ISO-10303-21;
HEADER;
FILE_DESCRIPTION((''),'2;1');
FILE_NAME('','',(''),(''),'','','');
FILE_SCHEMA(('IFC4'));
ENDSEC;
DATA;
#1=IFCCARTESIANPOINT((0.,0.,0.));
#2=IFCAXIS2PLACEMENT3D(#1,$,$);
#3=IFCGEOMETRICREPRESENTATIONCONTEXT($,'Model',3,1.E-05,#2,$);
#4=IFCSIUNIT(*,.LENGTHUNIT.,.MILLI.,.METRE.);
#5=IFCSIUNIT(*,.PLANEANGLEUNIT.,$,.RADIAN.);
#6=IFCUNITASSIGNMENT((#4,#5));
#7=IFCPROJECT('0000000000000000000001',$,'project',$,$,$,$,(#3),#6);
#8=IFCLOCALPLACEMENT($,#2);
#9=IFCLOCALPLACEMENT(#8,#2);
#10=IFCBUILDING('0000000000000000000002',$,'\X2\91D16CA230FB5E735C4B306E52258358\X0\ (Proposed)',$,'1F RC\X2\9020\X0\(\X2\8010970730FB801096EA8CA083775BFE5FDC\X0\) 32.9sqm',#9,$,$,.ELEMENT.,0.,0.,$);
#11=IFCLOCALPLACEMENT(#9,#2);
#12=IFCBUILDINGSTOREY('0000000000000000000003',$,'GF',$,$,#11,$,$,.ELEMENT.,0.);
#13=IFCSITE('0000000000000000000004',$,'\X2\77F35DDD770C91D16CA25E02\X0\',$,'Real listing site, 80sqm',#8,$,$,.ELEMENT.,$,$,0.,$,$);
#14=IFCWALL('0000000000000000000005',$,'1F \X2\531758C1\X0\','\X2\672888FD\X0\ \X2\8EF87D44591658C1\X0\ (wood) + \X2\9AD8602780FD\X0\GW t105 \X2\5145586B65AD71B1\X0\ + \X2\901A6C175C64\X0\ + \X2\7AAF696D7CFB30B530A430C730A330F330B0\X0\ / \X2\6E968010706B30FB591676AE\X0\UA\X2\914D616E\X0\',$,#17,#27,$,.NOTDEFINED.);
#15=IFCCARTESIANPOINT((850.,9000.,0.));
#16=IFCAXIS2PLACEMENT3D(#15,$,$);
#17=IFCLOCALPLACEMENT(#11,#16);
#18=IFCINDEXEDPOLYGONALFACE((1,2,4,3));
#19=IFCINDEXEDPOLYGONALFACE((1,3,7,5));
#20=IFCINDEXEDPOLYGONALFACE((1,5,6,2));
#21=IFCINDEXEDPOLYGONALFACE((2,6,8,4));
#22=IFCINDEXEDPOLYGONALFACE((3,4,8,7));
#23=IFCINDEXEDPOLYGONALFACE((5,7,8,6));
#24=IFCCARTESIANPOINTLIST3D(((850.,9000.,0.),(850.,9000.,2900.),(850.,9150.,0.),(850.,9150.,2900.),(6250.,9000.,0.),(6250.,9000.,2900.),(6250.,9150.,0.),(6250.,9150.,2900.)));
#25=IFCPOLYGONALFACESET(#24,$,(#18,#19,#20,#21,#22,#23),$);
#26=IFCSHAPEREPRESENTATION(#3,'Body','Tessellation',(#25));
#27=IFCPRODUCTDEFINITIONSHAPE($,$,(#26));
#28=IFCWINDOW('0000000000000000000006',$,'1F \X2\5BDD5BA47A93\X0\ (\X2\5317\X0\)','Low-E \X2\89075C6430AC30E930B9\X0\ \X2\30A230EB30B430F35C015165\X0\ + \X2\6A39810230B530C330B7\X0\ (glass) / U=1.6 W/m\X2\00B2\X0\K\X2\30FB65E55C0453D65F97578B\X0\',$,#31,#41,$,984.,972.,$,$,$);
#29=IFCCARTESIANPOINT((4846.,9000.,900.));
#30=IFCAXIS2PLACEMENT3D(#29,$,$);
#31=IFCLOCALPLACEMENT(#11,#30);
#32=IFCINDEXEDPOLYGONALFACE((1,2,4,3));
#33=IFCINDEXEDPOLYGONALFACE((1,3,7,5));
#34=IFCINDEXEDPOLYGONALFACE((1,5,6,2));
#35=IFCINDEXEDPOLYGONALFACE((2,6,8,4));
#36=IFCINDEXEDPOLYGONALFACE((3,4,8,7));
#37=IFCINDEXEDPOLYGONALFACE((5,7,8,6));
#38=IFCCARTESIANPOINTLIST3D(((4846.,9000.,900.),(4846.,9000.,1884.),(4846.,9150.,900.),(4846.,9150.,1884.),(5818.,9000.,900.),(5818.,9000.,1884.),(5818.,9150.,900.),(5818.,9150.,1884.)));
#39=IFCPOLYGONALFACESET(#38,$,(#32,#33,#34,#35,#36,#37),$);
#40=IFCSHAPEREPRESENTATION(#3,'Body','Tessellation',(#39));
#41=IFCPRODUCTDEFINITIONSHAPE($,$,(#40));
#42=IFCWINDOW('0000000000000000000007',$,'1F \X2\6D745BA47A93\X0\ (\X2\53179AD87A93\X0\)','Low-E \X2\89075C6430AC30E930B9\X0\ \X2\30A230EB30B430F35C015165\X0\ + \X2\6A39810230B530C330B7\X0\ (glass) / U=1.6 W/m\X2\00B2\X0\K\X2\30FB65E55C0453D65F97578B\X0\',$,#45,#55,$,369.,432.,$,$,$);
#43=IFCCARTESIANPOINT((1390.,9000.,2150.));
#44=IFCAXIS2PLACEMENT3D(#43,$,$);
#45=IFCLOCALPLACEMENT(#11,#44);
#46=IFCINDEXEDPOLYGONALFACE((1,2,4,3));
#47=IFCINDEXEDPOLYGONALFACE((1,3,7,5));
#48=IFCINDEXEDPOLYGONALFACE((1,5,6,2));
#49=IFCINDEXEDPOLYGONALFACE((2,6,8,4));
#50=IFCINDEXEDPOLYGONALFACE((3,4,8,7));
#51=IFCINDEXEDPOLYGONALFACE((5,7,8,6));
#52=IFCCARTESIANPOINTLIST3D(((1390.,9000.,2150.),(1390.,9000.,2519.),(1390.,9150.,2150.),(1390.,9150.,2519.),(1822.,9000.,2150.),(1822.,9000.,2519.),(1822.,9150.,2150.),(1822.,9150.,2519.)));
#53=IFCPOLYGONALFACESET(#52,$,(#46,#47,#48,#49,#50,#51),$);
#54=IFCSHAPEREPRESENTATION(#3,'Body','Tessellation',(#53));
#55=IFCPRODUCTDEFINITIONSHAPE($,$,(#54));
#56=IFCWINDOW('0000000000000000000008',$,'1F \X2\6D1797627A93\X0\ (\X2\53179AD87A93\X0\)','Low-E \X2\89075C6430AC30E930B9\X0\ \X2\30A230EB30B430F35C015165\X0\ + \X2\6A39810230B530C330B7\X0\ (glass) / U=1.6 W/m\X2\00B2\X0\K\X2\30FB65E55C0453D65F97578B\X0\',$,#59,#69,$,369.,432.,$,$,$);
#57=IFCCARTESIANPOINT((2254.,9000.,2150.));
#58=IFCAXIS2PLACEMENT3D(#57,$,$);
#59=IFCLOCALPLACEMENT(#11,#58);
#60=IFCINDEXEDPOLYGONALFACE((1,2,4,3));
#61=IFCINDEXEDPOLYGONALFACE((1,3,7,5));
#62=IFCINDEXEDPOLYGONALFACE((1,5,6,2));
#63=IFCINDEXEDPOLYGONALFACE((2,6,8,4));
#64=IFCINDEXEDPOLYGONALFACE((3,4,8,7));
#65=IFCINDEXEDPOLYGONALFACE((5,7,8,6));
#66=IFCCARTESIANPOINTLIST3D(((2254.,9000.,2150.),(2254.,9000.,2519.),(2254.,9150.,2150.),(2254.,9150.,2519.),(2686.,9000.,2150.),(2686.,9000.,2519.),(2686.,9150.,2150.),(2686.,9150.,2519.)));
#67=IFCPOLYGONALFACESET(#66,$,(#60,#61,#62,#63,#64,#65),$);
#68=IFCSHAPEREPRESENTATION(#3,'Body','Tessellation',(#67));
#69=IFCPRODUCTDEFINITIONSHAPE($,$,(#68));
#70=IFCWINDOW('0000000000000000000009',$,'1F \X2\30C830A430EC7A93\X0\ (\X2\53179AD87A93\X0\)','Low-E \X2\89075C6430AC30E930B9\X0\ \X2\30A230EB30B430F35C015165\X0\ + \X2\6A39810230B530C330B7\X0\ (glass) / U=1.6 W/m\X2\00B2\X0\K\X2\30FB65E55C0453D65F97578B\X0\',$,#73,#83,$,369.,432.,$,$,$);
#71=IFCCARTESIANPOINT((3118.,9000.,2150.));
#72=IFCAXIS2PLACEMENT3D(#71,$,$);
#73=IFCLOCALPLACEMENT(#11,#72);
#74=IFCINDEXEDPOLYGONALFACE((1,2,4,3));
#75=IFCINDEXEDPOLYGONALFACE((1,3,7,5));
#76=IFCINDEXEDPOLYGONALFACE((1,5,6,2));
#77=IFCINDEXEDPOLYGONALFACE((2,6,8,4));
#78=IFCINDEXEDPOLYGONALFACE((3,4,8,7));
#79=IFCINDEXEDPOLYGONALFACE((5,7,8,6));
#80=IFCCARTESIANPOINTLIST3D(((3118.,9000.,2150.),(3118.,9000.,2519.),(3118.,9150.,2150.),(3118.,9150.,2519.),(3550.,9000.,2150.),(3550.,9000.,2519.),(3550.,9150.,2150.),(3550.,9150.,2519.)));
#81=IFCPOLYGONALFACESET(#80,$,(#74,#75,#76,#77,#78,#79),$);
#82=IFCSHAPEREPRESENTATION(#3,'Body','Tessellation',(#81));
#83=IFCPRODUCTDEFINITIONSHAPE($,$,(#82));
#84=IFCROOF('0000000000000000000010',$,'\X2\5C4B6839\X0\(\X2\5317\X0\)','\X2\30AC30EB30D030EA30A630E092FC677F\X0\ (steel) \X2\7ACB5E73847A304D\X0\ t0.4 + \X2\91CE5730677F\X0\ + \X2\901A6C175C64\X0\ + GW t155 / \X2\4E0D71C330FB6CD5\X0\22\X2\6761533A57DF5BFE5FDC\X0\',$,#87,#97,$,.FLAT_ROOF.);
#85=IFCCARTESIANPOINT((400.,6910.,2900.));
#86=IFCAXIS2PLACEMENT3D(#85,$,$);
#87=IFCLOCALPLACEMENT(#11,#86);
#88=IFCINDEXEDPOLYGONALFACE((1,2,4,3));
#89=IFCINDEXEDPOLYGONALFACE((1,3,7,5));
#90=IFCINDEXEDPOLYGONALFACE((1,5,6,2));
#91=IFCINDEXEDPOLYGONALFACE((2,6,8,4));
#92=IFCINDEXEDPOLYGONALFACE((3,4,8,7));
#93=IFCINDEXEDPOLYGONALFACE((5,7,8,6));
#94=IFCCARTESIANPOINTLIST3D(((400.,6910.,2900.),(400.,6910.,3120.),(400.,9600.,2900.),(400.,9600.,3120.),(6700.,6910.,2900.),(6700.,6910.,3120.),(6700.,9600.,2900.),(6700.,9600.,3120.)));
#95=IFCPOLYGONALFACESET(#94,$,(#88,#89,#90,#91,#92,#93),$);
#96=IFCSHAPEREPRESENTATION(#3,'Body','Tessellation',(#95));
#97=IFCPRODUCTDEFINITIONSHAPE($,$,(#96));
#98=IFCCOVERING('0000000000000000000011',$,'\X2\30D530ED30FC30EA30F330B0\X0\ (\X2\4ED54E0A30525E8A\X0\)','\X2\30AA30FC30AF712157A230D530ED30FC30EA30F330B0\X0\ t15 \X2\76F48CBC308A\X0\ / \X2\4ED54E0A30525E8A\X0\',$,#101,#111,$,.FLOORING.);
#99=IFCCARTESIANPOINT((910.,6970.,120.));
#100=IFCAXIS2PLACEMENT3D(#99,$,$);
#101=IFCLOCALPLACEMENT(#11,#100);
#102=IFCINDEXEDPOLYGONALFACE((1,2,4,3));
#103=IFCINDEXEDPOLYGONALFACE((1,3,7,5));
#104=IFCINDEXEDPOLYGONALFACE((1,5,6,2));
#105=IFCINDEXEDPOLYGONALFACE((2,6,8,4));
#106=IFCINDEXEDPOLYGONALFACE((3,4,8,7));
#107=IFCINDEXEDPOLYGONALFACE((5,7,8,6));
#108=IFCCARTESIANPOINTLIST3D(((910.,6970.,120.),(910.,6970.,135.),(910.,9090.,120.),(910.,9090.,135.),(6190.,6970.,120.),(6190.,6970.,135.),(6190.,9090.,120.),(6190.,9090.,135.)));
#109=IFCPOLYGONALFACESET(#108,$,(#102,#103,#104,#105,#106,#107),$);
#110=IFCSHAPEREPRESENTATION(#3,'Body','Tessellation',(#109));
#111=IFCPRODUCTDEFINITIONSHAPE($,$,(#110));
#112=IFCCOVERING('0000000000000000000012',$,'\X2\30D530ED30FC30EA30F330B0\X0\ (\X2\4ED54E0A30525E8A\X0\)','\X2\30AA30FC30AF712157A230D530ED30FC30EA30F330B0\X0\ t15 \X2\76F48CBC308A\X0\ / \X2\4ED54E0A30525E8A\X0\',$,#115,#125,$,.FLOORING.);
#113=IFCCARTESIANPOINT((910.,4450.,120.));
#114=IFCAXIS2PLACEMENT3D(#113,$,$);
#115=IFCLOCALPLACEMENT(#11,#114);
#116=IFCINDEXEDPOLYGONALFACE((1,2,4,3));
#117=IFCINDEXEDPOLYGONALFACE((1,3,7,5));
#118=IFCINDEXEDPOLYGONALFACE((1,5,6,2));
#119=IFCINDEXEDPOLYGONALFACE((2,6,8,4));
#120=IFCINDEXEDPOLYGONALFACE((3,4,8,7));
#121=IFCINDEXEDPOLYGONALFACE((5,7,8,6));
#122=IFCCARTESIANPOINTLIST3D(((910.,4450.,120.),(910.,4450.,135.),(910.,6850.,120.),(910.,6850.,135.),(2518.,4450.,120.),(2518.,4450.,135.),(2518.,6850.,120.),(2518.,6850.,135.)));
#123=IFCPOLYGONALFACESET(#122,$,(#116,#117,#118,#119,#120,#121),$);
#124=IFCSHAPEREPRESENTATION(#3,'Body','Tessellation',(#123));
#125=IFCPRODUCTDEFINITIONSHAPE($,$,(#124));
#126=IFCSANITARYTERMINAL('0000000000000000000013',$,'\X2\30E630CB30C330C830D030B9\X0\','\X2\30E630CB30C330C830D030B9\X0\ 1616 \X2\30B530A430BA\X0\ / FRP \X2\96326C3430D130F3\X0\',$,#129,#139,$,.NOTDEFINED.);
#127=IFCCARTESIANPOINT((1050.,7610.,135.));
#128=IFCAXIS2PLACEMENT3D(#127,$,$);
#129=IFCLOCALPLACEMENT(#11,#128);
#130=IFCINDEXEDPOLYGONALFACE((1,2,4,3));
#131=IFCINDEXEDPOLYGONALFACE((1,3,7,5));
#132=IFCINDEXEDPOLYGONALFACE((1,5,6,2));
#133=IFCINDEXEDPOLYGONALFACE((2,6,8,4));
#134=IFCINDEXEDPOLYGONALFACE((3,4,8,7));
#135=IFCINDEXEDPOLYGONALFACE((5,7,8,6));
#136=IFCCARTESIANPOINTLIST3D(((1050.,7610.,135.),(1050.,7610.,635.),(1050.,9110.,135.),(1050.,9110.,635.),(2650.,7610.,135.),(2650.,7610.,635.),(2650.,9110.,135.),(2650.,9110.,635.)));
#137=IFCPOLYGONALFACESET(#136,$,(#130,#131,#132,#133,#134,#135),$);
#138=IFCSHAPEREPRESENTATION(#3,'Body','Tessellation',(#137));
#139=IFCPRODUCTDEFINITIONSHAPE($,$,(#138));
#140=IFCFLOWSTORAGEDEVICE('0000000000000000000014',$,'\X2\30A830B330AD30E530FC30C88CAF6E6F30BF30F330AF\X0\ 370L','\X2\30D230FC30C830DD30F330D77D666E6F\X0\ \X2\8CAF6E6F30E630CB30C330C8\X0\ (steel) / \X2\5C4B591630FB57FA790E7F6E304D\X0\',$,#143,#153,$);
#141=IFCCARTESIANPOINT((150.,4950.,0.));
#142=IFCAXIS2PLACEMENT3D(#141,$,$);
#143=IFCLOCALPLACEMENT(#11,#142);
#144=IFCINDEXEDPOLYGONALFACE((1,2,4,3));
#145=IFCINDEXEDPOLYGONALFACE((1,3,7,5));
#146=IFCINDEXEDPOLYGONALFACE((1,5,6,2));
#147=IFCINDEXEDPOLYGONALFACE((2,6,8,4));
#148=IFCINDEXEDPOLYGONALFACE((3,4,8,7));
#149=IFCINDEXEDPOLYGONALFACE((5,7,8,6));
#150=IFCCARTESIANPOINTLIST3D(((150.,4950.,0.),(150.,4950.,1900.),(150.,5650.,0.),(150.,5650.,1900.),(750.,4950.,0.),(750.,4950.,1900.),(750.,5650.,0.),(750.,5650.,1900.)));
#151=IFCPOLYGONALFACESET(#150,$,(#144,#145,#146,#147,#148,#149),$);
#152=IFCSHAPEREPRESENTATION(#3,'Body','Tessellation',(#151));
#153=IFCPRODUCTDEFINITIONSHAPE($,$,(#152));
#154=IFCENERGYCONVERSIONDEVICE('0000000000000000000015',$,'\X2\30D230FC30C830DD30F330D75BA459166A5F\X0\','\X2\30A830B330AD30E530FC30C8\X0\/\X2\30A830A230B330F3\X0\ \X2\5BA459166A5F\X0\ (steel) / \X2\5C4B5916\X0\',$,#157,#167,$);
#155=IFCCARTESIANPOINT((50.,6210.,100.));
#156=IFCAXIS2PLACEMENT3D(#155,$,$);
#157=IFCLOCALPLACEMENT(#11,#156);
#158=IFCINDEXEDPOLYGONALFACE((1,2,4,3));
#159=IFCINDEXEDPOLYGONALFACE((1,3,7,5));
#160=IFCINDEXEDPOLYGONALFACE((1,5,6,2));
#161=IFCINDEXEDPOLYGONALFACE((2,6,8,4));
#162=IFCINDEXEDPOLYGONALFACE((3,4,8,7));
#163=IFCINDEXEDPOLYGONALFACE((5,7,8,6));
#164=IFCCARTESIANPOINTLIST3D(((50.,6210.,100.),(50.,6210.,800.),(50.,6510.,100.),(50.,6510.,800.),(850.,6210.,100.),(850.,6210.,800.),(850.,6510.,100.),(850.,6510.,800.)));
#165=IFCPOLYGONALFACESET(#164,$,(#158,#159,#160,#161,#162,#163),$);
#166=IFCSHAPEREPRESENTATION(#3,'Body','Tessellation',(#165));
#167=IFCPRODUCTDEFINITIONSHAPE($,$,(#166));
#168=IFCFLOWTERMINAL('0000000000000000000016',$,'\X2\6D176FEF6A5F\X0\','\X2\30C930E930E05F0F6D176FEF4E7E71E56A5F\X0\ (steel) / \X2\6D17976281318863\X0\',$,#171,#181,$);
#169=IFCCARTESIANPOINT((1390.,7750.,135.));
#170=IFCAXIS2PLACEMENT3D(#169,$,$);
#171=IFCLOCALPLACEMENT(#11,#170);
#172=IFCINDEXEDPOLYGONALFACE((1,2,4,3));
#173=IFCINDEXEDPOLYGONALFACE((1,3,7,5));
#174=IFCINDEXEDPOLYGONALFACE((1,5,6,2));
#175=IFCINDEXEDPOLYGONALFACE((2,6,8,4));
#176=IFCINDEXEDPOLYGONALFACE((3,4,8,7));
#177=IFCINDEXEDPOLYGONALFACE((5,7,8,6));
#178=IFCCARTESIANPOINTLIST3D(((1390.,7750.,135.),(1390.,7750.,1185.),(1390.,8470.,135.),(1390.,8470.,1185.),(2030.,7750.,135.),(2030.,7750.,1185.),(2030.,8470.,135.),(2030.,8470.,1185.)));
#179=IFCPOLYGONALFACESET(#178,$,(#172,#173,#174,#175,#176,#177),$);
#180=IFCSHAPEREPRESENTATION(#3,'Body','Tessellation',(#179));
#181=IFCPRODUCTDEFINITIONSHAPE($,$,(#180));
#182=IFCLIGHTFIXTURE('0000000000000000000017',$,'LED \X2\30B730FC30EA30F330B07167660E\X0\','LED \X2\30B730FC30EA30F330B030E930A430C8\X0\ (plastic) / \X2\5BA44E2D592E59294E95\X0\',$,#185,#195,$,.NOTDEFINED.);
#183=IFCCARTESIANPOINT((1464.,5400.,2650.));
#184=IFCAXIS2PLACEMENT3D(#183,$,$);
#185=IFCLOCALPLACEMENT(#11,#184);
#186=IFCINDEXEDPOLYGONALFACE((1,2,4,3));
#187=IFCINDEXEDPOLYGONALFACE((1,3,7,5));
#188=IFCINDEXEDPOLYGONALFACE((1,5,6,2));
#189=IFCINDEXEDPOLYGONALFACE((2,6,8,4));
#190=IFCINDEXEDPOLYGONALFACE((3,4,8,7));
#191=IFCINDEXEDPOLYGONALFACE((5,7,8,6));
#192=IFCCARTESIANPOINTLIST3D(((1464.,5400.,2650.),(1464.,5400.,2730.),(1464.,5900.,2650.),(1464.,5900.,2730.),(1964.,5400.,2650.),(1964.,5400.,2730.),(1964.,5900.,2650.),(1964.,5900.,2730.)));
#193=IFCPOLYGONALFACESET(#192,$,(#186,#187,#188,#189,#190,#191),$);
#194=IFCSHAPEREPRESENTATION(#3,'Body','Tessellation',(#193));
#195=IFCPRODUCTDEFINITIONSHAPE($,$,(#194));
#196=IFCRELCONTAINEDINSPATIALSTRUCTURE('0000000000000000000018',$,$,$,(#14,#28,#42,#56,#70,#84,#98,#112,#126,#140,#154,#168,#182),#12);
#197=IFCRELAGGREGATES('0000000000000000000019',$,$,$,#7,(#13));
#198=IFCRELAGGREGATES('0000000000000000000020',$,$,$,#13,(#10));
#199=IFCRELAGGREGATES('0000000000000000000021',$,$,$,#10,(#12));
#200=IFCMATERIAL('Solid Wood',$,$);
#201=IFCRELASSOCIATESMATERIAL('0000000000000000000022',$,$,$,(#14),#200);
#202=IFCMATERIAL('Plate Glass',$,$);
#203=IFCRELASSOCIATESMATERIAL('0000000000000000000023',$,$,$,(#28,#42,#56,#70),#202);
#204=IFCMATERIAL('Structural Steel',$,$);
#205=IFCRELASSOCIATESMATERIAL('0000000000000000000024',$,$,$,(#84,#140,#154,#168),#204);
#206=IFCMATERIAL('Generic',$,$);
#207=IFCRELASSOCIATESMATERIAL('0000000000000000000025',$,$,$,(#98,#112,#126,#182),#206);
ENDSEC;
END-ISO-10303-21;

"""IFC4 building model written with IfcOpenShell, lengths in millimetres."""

from ifc_helpers import new_model, si_unit, frame, frame_2d, origin, place, context, project, spatial, rectangle, extrude, material, element, fill, save


model = new_model("IFC4")

# Units and contexts
model_context = context("Model", 3, precision=1e-05, world=origin())
ifc_project = project(units=[si_unit("LENGTHUNIT", "METRE", prefix="MILLI"), si_unit("PLANEANGLEUNIT", "RADIAN")], contexts=[model_context])

# Site, building, storey
site_placement = place(None, origin())
site = spatial("IfcSite", under=ifc_project, at=site_placement, Name="石川県金沢市", ObjectType="Real listing site, 80sqm", CompositionType="ELEMENT", RefElevation=0.0)
building_placement = place(site_placement, origin())
building = spatial("IfcBuilding", under=site, at=building_placement, Name="金沢・平屋の別荘 (Proposed)", ObjectType="1F RC造(耐震・耐雪負荷対応) 32.9sqm", CompositionType="ELEMENT", ElevationOfRefHeight=0.0, ElevationOfTerrain=0.0)
storey_placement = place(building_placement, origin())
storey = spatial("IfcBuildingStorey", under=building, at=storey_placement, Name="GF", CompositionType="ELEMENT", Elevation=0.0)

# Shared definitions
ifc_material_1 = material(Name="Solid Wood")

# Wall, openings, windows
wall_1_placement = place(storey_placement, frame((850.0, 9000.0, 0.0)))
wall_1 = element("IfcWall", 1, at=wall_1_placement, inside=storey, material=ifc_material_1, Name="1F 北壁", Description="木製 軸組外壁 (wood) + 高性能GW t105 充填断熱 + 通気層 + 窯業系サイディング / 準耐火・外皮UA配慮", PredefinedType="NOTDEFINED", context=model_context, shape_type="SweptSolid", body=[
    extrude(rectangle(XDim=5400.0, YDim=150.0, at=frame_2d((2700.0, 75.0))), frame((850.0, 9000.0, 0.0)), (0.0, 0.0, 1.0), 2900.0),
])
opening_1_placement = place(storey_placement, frame((4846.0, 9000.0, 900.0)))
opening_1 = element("IfcOpeningElement", 2, at=opening_1_placement, cuts=wall_1, PredefinedType="NOTDEFINED", context=model_context, shape_type="SweptSolid", body=[
    extrude(rectangle(XDim=972.0, YDim=150.0, at=frame_2d((486.0, 75.0))), frame((4846.0, 9000.0, 900.0)), (0.0, 0.0, 1.0), 984.0),
])
opening_2_placement = place(storey_placement, frame((1390.0, 9000.0, 2150.0)))
opening_2 = element("IfcOpeningElement", 3, at=opening_2_placement, cuts=wall_1, PredefinedType="NOTDEFINED", context=model_context, shape_type="SweptSolid", body=[
    extrude(rectangle(XDim=432.0, YDim=150.0, at=frame_2d((216.0, 75.0))), frame((1390.0, 9000.0, 2150.0)), (0.0, 0.0, 1.0), 369.0),
])
opening_3_placement = place(storey_placement, frame((2254.0, 9000.0, 2150.0)))
opening_3 = element("IfcOpeningElement", 4, at=opening_3_placement, cuts=wall_1, PredefinedType="NOTDEFINED", context=model_context, shape_type="SweptSolid", body=[
    extrude(rectangle(XDim=432.0, YDim=150.0, at=frame_2d((216.0, 75.0))), frame((2254.0, 9000.0, 2150.0)), (0.0, 0.0, 1.0), 369.0),
])
opening_4_placement = place(storey_placement, frame((3118.0, 9000.0, 2150.0)))
opening_4 = element("IfcOpeningElement", 5, at=opening_4_placement, cuts=wall_1, PredefinedType="NOTDEFINED", context=model_context, shape_type="SweptSolid", body=[
    extrude(rectangle(XDim=432.0, YDim=150.0, at=frame_2d((216.0, 75.0))), frame((3118.0, 9000.0, 2150.0)), (0.0, 0.0, 1.0), 369.0),
])
ifc_material_2 = material(Name="Plate Glass")
window_1_placement = place(storey_placement, frame((4846.0, 9000.0, 900.0)))
window_1 = element("IfcWindow", 6, at=window_1_placement, inside=storey, material=ifc_material_2, Name="1F 寝室窓 (北)", Description="Low-E 複層ガラス アルゴン封入 + 樹脂サッシ (glass) / U=1.6 W/m²K・日射取得型", OverallHeight=984.0, OverallWidth=972.0, context=model_context, shape_type="SweptSolid", body=[
    extrude(rectangle(XDim=972.0, YDim=150.0, at=frame_2d((486.0, 75.0))), frame((4846.0, 9000.0, 900.0)), (0.0, 0.0, 1.0), 984.0),
])
fill(opening_1, window_1)
window_2_placement = place(storey_placement, frame((1390.0, 9000.0, 2150.0)))
window_2 = element("IfcWindow", 7, at=window_2_placement, inside=storey, material=ifc_material_2, Name="1F 浴室窓 (北高窓)", Description="Low-E 複層ガラス アルゴン封入 + 樹脂サッシ (glass) / U=1.6 W/m²K・日射取得型", OverallHeight=369.0, OverallWidth=432.0, context=model_context, shape_type="SweptSolid", body=[
    extrude(rectangle(XDim=432.0, YDim=150.0, at=frame_2d((216.0, 75.0))), frame((1390.0, 9000.0, 2150.0)), (0.0, 0.0, 1.0), 369.0),
])
fill(opening_2, window_2)
window_3_placement = place(storey_placement, frame((2254.0, 9000.0, 2150.0)))
window_3 = element("IfcWindow", 8, at=window_3_placement, inside=storey, material=ifc_material_2, Name="1F 洗面窓 (北高窓)", Description="Low-E 複層ガラス アルゴン封入 + 樹脂サッシ (glass) / U=1.6 W/m²K・日射取得型", OverallHeight=369.0, OverallWidth=432.0, context=model_context, shape_type="SweptSolid", body=[
    extrude(rectangle(XDim=432.0, YDim=150.0, at=frame_2d((216.0, 75.0))), frame((2254.0, 9000.0, 2150.0)), (0.0, 0.0, 1.0), 369.0),
])
fill(opening_3, window_3)
window_4_placement = place(storey_placement, frame((3118.0, 9000.0, 2150.0)))
window_4 = element("IfcWindow", 9, at=window_4_placement, inside=storey, material=ifc_material_2, Name="1F トイレ窓 (北高窓)", Description="Low-E 複層ガラス アルゴン封入 + 樹脂サッシ (glass) / U=1.6 W/m²K・日射取得型", OverallHeight=369.0, OverallWidth=432.0, context=model_context, shape_type="SweptSolid", body=[
    extrude(rectangle(XDim=432.0, YDim=150.0, at=frame_2d((216.0, 75.0))), frame((3118.0, 9000.0, 2150.0)), (0.0, 0.0, 1.0), 369.0),
])
fill(opening_4, window_4)

# Roof
ifc_material_3 = material(Name="Structural Steel")
roof_placement = place(storey_placement, frame((400.0, 6910.0, 2900.0)))
element("IfcRoof", 10, at=roof_placement, inside=storey, material=ifc_material_3, Name="屋根(北)", Description="ガルバリウム鋼板 (steel) 立平葺き t0.4 + 野地板 + 通気層 + GW t155 / 不燃・法22条区域対応", PredefinedType="FLAT_ROOF", context=model_context, shape_type="SweptSolid", body=[
    extrude(rectangle(XDim=6300.0, YDim=2690.0, at=frame_2d((3150.0, 1345.0))), frame((400.0, 6910.0, 2900.0)), (0.0, 0.0, 1.0), 220.0),
])

# Coverings
ifc_material_4 = material(Name="Generic")
covering_1_placement = place(storey_placement, frame((910.0, 6970.0, 120.0)))
element("IfcCovering", 11, at=covering_1_placement, inside=storey, material=ifc_material_4, Name="フローリング (仕上げ床)", Description="オーク無垢フローリング t15 直貼り / 仕上げ床", PredefinedType="FLOORING", context=model_context, shape_type="SweptSolid", body=[
    extrude(rectangle(XDim=5280.0, YDim=2120.0, at=frame_2d((2640.0, 1060.0))), frame((910.0, 6970.0, 120.0)), (0.0, 0.0, 1.0), 15.0),
])
covering_2_placement = place(storey_placement, frame((910.0, 4450.0, 120.0)))
element("IfcCovering", 12, at=covering_2_placement, inside=storey, material=ifc_material_4, Name="フローリング (仕上げ床)", Description="オーク無垢フローリング t15 直貼り / 仕上げ床", PredefinedType="FLOORING", context=model_context, shape_type="SweptSolid", body=[
    extrude(rectangle(XDim=1608.0, YDim=2400.0, at=frame_2d((804.0, 1200.0))), frame((910.0, 4450.0, 120.0)), (0.0, 0.0, 1.0), 15.0),
])

# Sanitary terminal
sanitary_terminal_placement = place(storey_placement, frame((1050.0, 7610.0, 135.0)))
element("IfcSanitaryTerminal", 13, at=sanitary_terminal_placement, inside=storey, material=ifc_material_4, Name="ユニットバス", Description="ユニットバス 1616 サイズ / FRP 防水パン", PredefinedType="NOTDEFINED", context=model_context, shape_type="SweptSolid", body=[
    extrude(rectangle(XDim=1600.0, YDim=1500.0, at=frame_2d((800.0, 750.0))), frame((1050.0, 7610.0, 135.0)), (0.0, 0.0, 1.0), 500.0),
])

# Flow storage device
flow_storage_device_placement = place(storey_placement, frame((150.0, 4950.0, 0.0)))
element("IfcFlowStorageDevice", 14, at=flow_storage_device_placement, inside=storey, material=ifc_material_3, Name="エコキュート貯湯タンク 370L", Description="ヒートポンプ給湯 貯湯ユニット (steel) / 屋外・基礎置き", context=model_context, shape_type="SweptSolid", body=[
    extrude(rectangle(XDim=600.0, YDim=700.0, at=frame_2d((300.0, 350.0))), frame((150.0, 4950.0, 0.0)), (0.0, 0.0, 1.0), 1900.0),
])

# Energy conversion device
energy_conversion_device_placement = place(storey_placement, frame((50.0, 6210.0, 100.0)))
element("IfcEnergyConversionDevice", 15, at=energy_conversion_device_placement, inside=storey, material=ifc_material_3, Name="ヒートポンプ室外機", Description="エコキュート/エアコン 室外機 (steel) / 屋外", context=model_context, shape_type="SweptSolid", body=[
    extrude(rectangle(XDim=800.0, YDim=300.0, at=frame_2d((400.0, 150.0))), frame((50.0, 6210.0, 100.0)), (0.0, 0.0, 1.0), 700.0),
])

# Flow terminal
flow_terminal_placement = place(storey_placement, frame((1390.0, 7750.0, 135.0)))
element("IfcFlowTerminal", 16, at=flow_terminal_placement, inside=storey, material=ifc_material_3, Name="洗濯機", Description="ドラム式洗濯乾燥機 (steel) / 洗面脱衣", context=model_context, shape_type="SweptSolid", body=[
    extrude(rectangle(XDim=640.0, YDim=720.0, at=frame_2d((320.0, 360.0))), frame((1390.0, 7750.0, 135.0)), (0.0, 0.0, 1.0), 1050.0),
])

# Light fixture
light_fixture_placement = place(storey_placement, frame((1464.0, 5400.0, 2650.0)))
element("IfcLightFixture", 17, at=light_fixture_placement, inside=storey, material=ifc_material_4, Name="LED シーリング照明", Description="LED シーリングライト (plastic) / 室中央天井", PredefinedType="NOTDEFINED", context=model_context, shape_type="SweptSolid", body=[
    extrude(rectangle(XDim=500.0, YDim=500.0, at=frame_2d((250.0, 250.0))), frame((1464.0, 5400.0, 2650.0)), (0.0, 0.0, 1.0), 80.0),
])

save(model, "model.ifc")
